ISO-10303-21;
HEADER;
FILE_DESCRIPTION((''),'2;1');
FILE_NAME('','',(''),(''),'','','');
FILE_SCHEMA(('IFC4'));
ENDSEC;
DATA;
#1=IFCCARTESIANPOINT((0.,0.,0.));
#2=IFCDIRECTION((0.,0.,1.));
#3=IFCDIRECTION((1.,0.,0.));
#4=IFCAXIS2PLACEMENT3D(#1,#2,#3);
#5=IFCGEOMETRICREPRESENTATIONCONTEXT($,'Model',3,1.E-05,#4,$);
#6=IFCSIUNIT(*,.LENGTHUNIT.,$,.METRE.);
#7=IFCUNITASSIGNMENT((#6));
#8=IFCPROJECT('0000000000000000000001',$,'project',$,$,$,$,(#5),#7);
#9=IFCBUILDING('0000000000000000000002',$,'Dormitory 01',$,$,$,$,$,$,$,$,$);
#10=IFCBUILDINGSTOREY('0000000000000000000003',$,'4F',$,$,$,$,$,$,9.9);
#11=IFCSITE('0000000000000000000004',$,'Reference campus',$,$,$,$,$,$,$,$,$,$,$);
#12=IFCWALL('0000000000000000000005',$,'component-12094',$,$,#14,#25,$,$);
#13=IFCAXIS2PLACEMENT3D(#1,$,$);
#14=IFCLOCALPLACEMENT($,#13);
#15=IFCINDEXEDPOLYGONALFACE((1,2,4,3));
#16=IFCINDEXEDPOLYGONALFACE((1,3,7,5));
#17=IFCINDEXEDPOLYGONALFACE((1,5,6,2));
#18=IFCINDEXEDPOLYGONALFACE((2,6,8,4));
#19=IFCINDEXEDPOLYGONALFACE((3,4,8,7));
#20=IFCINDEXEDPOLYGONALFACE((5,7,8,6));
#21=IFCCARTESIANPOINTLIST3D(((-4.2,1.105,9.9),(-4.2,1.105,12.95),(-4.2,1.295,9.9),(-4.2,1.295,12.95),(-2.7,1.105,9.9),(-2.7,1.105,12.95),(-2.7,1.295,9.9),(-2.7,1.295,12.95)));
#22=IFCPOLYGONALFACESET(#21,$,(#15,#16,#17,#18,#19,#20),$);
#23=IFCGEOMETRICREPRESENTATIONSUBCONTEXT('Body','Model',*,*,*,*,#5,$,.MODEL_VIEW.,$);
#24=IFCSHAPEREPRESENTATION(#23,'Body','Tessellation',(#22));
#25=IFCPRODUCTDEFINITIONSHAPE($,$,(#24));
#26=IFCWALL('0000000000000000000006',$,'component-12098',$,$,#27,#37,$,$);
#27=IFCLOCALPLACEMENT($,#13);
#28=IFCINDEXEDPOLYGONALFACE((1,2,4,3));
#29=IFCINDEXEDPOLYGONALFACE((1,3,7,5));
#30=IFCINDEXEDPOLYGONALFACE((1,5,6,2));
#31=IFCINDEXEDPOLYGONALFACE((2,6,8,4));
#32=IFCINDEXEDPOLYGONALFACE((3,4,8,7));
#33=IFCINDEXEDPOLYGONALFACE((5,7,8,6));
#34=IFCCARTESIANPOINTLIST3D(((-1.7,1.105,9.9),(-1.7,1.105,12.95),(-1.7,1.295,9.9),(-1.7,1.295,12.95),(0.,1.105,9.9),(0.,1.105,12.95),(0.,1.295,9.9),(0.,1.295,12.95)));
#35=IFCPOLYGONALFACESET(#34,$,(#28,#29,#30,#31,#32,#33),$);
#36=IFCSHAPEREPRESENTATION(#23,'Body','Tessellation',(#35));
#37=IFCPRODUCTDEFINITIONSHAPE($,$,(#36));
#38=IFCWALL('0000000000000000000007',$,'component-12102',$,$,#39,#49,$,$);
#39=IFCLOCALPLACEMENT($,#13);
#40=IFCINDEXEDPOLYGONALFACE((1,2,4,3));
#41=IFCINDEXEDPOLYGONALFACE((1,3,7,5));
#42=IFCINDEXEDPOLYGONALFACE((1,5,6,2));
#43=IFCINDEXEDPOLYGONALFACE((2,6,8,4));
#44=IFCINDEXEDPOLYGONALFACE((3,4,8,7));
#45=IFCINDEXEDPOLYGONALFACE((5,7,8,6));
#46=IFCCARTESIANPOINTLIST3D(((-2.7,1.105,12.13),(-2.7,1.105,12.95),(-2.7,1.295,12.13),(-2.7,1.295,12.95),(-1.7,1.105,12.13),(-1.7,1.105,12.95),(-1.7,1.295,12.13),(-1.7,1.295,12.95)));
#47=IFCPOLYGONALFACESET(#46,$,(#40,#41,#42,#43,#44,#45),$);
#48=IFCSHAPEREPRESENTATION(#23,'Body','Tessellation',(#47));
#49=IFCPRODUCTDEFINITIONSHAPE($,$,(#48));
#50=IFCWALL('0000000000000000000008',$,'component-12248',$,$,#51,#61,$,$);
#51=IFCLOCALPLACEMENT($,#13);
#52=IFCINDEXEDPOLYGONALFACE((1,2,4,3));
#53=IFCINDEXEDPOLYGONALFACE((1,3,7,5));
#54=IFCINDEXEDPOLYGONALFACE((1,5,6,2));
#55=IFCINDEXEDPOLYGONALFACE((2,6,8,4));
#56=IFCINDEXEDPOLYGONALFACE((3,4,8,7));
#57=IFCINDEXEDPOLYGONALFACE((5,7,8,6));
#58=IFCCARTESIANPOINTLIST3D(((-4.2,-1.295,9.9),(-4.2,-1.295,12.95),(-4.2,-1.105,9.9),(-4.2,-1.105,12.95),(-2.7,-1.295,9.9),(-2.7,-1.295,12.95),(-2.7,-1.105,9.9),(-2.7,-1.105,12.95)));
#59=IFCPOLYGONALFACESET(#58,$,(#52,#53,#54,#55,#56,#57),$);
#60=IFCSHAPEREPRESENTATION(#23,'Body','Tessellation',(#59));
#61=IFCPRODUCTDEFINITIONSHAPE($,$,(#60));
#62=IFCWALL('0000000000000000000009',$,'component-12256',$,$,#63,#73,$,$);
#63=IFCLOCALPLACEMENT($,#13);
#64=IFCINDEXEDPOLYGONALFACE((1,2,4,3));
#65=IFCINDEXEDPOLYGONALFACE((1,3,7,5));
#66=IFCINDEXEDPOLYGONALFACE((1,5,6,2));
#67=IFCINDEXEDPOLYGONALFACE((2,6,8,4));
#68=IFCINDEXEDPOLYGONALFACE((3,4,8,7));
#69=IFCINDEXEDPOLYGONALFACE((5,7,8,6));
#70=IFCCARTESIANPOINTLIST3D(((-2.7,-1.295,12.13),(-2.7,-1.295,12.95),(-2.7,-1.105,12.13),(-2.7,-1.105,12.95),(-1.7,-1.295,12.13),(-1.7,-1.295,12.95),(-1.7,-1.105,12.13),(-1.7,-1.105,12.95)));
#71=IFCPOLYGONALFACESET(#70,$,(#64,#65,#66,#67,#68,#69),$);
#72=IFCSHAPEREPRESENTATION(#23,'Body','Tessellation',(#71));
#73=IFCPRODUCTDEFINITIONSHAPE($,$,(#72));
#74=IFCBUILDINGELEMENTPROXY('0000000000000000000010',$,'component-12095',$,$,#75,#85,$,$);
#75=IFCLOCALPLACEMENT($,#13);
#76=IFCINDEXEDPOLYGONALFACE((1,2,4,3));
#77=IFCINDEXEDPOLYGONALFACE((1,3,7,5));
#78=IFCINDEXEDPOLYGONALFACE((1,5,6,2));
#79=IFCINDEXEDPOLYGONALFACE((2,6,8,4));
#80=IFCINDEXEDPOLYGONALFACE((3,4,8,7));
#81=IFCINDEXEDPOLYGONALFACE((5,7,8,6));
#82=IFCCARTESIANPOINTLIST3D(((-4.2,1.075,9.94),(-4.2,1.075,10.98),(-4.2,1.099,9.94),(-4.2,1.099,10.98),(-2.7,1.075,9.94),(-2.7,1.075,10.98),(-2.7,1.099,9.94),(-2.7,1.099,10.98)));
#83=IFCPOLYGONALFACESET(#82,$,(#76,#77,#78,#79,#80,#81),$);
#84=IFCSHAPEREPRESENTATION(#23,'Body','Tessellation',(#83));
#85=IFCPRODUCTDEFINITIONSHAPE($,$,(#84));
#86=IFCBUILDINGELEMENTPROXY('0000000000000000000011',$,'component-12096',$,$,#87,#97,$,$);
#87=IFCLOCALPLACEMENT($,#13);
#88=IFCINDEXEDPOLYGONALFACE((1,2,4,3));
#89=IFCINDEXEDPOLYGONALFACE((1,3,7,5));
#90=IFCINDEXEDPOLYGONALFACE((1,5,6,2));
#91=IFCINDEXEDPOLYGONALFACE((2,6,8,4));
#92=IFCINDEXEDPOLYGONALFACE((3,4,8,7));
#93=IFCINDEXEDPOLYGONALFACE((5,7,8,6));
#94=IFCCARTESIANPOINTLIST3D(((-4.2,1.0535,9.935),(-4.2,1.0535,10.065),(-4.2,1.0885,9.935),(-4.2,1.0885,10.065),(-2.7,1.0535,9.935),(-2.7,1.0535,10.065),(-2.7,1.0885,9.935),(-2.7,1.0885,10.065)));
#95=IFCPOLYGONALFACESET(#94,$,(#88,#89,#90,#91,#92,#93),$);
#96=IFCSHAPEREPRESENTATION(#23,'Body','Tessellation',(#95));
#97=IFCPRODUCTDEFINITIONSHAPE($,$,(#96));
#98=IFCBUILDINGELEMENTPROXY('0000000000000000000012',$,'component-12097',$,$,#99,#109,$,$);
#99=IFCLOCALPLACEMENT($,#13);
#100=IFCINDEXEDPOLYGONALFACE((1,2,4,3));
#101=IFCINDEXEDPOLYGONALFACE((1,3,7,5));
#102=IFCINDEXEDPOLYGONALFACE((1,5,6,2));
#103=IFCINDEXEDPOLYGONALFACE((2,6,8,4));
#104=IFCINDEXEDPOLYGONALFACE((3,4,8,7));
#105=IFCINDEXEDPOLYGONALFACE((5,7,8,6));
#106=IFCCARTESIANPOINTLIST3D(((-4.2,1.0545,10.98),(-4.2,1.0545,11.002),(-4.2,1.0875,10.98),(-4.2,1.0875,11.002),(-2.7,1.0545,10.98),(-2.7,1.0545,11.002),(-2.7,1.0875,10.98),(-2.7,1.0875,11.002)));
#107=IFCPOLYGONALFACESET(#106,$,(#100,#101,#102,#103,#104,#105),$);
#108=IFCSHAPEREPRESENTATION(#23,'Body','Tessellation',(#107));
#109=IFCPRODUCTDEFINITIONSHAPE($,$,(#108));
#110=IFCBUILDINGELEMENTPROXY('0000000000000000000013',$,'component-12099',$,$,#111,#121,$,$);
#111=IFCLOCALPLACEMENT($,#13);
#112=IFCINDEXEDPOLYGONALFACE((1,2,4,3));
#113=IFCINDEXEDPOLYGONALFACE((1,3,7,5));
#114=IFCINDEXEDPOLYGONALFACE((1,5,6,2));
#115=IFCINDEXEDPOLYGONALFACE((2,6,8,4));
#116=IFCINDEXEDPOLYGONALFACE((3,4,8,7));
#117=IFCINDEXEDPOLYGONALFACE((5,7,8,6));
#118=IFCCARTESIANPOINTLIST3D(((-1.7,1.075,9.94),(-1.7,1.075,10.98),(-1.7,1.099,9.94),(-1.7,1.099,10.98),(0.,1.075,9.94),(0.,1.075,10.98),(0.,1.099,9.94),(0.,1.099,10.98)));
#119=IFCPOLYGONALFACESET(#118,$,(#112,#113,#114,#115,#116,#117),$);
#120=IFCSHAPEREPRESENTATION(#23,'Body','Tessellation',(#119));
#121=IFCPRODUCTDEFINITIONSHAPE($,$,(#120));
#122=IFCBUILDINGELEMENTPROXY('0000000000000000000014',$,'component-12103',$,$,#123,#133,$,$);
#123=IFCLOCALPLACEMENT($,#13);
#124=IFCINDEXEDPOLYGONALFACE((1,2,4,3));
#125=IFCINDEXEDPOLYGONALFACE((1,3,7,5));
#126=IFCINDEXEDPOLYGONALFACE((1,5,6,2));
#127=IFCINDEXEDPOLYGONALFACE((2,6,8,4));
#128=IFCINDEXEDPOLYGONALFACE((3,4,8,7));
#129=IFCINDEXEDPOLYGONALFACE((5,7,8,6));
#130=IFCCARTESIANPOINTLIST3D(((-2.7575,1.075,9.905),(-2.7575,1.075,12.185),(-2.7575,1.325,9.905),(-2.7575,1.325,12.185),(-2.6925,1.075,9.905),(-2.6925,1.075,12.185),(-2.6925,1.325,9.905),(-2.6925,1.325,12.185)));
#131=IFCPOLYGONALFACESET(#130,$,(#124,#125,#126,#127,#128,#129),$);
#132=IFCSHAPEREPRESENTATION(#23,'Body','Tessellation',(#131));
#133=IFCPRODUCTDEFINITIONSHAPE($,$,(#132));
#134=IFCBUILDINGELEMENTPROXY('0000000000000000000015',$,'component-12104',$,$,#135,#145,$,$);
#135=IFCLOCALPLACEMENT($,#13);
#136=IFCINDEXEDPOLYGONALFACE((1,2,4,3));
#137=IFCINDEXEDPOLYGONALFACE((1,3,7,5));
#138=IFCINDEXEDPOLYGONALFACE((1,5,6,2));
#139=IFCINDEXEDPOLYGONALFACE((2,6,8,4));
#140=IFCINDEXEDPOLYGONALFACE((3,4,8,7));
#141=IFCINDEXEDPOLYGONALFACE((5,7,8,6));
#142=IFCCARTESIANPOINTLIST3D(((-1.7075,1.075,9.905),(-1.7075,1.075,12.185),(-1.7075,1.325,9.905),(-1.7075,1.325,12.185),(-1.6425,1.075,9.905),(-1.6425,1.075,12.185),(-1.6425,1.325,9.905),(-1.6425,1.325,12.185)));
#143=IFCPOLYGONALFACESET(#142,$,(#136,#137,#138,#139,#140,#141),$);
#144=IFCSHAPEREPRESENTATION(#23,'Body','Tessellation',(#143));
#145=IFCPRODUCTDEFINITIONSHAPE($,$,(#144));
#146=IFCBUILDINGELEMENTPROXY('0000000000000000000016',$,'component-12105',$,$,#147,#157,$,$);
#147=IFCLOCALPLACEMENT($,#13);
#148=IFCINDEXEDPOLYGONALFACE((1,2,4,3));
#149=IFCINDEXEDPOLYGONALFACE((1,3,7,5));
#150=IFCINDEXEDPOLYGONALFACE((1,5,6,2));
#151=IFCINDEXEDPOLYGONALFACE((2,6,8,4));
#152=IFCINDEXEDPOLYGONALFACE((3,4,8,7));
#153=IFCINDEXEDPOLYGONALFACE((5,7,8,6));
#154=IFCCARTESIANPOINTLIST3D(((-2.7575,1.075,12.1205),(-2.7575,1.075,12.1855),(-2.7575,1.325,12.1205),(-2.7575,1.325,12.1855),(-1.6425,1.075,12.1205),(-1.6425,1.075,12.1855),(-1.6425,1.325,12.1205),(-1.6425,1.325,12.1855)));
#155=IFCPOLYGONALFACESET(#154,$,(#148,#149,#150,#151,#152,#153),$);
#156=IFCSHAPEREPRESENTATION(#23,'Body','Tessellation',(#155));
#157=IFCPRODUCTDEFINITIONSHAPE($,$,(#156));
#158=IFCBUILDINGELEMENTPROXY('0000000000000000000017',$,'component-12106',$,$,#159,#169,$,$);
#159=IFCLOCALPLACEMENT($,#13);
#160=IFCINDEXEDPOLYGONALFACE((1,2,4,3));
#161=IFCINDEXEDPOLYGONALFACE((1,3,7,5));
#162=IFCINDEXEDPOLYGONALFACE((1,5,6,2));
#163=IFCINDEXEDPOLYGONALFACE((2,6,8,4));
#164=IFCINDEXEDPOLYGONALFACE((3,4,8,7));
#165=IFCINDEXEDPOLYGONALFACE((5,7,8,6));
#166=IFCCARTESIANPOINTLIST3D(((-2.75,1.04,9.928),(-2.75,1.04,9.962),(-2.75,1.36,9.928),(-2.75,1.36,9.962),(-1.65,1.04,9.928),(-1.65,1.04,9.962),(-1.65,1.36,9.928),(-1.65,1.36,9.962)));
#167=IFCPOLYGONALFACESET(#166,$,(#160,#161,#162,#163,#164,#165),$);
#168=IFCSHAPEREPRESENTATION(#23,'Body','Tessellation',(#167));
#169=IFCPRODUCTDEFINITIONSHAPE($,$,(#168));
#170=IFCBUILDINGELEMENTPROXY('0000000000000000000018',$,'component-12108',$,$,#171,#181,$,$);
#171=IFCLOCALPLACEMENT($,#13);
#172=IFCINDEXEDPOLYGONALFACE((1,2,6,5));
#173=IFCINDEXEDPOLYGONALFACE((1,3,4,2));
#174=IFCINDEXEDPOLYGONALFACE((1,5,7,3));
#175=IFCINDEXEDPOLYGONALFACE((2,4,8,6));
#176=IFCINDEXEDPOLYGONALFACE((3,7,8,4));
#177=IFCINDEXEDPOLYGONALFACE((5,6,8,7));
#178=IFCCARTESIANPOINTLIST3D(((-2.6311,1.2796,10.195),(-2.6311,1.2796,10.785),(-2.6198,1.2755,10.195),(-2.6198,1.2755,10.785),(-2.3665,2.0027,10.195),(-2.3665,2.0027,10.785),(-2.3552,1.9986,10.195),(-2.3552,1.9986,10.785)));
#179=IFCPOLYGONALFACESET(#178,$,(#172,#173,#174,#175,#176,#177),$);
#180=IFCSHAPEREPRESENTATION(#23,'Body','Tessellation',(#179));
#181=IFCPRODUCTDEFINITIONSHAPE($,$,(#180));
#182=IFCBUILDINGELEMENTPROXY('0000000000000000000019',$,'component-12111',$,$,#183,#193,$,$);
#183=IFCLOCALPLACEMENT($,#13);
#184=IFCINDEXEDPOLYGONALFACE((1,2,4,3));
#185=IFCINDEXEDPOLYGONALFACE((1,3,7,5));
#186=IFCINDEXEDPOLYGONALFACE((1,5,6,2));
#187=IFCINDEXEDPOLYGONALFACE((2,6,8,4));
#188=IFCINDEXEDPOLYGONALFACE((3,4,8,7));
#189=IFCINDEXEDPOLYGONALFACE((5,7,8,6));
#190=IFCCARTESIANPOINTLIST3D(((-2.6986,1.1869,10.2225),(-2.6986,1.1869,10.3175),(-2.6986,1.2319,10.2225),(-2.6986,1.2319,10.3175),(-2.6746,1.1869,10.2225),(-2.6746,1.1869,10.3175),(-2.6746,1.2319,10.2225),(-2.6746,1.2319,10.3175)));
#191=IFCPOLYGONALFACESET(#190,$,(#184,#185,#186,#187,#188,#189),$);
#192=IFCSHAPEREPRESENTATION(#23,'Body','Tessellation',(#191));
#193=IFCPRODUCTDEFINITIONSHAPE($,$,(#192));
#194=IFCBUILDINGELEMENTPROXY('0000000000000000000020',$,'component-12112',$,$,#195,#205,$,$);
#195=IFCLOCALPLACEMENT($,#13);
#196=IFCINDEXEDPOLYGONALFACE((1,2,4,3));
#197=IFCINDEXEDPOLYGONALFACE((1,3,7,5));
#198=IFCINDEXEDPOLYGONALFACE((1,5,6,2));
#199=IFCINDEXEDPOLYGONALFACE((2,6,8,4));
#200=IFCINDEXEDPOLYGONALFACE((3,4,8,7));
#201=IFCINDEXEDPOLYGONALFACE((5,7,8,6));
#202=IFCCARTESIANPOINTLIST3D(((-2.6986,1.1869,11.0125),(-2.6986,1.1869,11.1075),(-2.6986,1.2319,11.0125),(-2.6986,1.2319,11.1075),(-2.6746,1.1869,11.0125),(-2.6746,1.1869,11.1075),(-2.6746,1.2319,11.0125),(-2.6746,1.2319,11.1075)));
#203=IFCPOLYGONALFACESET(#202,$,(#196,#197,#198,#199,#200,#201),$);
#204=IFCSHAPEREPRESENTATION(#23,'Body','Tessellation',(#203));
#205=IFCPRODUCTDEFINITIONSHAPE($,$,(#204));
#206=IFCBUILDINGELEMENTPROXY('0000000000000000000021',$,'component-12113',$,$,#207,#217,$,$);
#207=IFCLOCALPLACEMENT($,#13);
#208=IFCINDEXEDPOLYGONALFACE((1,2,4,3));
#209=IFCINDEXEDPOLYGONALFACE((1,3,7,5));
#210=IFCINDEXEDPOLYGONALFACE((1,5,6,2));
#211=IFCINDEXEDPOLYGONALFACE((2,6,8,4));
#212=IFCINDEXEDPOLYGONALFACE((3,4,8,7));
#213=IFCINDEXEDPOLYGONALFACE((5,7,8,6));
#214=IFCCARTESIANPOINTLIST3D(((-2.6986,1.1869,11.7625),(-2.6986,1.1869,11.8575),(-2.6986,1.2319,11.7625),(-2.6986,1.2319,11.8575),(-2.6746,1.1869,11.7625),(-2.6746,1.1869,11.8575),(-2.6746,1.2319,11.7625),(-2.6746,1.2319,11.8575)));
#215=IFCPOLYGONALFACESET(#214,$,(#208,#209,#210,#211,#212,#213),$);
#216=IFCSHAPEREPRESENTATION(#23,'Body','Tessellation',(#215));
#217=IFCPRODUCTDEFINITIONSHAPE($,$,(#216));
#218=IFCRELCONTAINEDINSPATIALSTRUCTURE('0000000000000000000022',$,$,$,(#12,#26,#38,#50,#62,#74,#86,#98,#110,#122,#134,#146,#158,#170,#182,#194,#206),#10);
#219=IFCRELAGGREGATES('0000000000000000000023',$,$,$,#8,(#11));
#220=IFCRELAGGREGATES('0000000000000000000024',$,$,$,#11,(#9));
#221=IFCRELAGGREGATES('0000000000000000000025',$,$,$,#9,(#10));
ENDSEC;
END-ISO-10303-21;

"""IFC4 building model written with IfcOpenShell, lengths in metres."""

from ifc_helpers import new_model, si_unit, frame, origin, origin_with_axes, origin_2d, place, context, subcontext, project, spatial, rectangle, extrude, element, save


model = new_model("IFC4")

# Units and contexts
model_context = context("Model", 3, precision=1e-05, world=origin_with_axes())
body_context = subcontext(model_context, "Body", "Model", "MODEL_VIEW")
ifc_project = project(units=[si_unit("LENGTHUNIT", "METRE")], contexts=[model_context])

# Site, building, storey
site = spatial("IfcSite", under=ifc_project, Name="Reference campus")
building = spatial("IfcBuilding", under=site, Name="Dormitory 01")
storey = spatial("IfcBuildingStorey", under=building, Name="4F", Elevation=9.9)

# Walls
wall_1_placement = place(None, frame((-3.45, 1.2, 9.9), z_axis=(0.0, 0.0, 1.0), x_axis=(1.0, 0.0, 0.0)))
element("IfcWall", 1, at=wall_1_placement, inside=storey, Name="component-12094", context=body_context, shape_type="SweptSolid", body=[
    extrude(rectangle(XDim=1.5, YDim=0.19, at=origin_2d()), origin(), (0.0, 0.0, 1.0), 3.05),
])
wall_2_placement = place(None, frame((-0.85, 1.2, 9.9), z_axis=(0.0, 0.0, 1.0), x_axis=(1.0, 0.0, 0.0)))
element("IfcWall", 2, at=wall_2_placement, inside=storey, Name="component-12098", context=body_context, shape_type="SweptSolid", body=[
    extrude(rectangle(XDim=1.7, YDim=0.19, at=origin_2d()), origin(), (0.0, 0.0, 1.0), 3.05),
])
wall_3_placement = place(None, frame((-2.2, 1.2, 12.13), z_axis=(0.0, 0.0, 1.0), x_axis=(1.0, 0.0, 0.0)))
element("IfcWall", 3, at=wall_3_placement, inside=storey, Name="component-12102", context=body_context, shape_type="SweptSolid", body=[
    extrude(rectangle(XDim=1.0, YDim=0.19, at=origin_2d()), origin(), (0.0, 0.0, 1.0), 0.82),
])
wall_4_placement = place(None, frame((-3.45, -1.2, 9.9), z_axis=(0.0, 0.0, 1.0), x_axis=(1.0, 0.0, 0.0)))
element("IfcWall", 4, at=wall_4_placement, inside=storey, Name="component-12248", context=body_context, shape_type="SweptSolid", body=[
    extrude(rectangle(XDim=1.5, YDim=0.19, at=origin_2d()), origin(), (0.0, 0.0, 1.0), 3.05),
])
wall_5_placement = place(None, frame((-2.2, -1.2, 12.13), z_axis=(0.0, 0.0, 1.0), x_axis=(1.0, 0.0, 0.0)))
element("IfcWall", 5, at=wall_5_placement, inside=storey, Name="component-12256", context=body_context, shape_type="SweptSolid", body=[
    extrude(rectangle(XDim=1.0, YDim=0.19, at=origin_2d()), origin(), (0.0, 0.0, 1.0), 0.82),
])

# Building element proxies
proxy_1_placement = place(None, frame((-3.45, 1.087, 9.94), z_axis=(0.0, 0.0, 1.0), x_axis=(1.0, 0.0, 0.0)))
element("IfcBuildingElementProxy", 6, at=proxy_1_placement, inside=storey, Name="component-12095", context=body_context, shape_type="SweptSolid", body=[
    extrude(rectangle(XDim=1.5, YDim=0.024, at=origin_2d()), origin(), (0.0, 0.0, 1.0), 1.04),
])
proxy_2_placement = place(None, frame((-3.45, 1.071, 9.935), z_axis=(0.0, 0.0, 1.0), x_axis=(1.0, 0.0, 0.0)))
element("IfcBuildingElementProxy", 7, at=proxy_2_placement, inside=storey, Name="component-12096", context=body_context, shape_type="SweptSolid", body=[
    extrude(rectangle(XDim=1.5, YDim=0.035, at=origin_2d()), origin(), (0.0, 0.0, 1.0), 0.13),
])
proxy_3_placement = place(None, frame((-3.45, 1.071, 10.98), z_axis=(0.0, 0.0, 1.0), x_axis=(1.0, 0.0, 0.0)))
element("IfcBuildingElementProxy", 8, at=proxy_3_placement, inside=storey, Name="component-12097", context=body_context, shape_type="SweptSolid", body=[
    extrude(rectangle(XDim=1.5, YDim=0.033, at=origin_2d()), origin(), (0.0, 0.0, 1.0), 0.022),
])
proxy_4_placement = place(None, frame((-0.85, 1.087, 9.94), z_axis=(0.0, 0.0, 1.0), x_axis=(1.0, 0.0, 0.0)))
element("IfcBuildingElementProxy", 9, at=proxy_4_placement, inside=storey, Name="component-12099", context=body_context, shape_type="SweptSolid", body=[
    extrude(rectangle(XDim=1.7, YDim=0.024, at=origin_2d()), origin(), (0.0, 0.0, 1.0), 1.04),
])
for number, where, z_axis, x_axis, name in (
    (10, (-2.725, 1.2, 9.905), (0.0, 0.0, 1.0), (1.0, 0.0, 0.0), "component-12103"),
    (11, (-1.675, 1.2, 9.905), (0.0, 0.0, 1.0), (1.0, 0.0, 0.0), "component-12104"),
):
    element("IfcBuildingElementProxy", number, at=place(None, frame(where, z_axis=z_axis, x_axis=x_axis)), inside=storey, Name=name, context=body_context, shape_type="SweptSolid", body=[
        extrude(rectangle(XDim=0.065, YDim=0.25, at=origin_2d()), origin(), (0.0, 0.0, 1.0), 2.28),
    ])
proxy_5_placement = place(None, frame((-2.2, 1.2, 12.1205), z_axis=(0.0, 0.0, 1.0), x_axis=(1.0, 0.0, 0.0)))
element("IfcBuildingElementProxy", 12, at=proxy_5_placement, inside=storey, Name="component-12105", context=body_context, shape_type="SweptSolid", body=[
    extrude(rectangle(XDim=1.115, YDim=0.25, at=origin_2d()), origin(), (0.0, 0.0, 1.0), 0.065),
])
proxy_6_placement = place(None, frame((-2.2, 1.2, 9.928), z_axis=(0.0, 0.0, 1.0), x_axis=(1.0, 0.0, 0.0)))
element("IfcBuildingElementProxy", 13, at=proxy_6_placement, inside=storey, Name="component-12106", context=body_context, shape_type="SweptSolid", body=[
    extrude(rectangle(XDim=1.1, YDim=0.32, at=origin_2d()), origin(), (0.0, 0.0, 1.0), 0.034),
])
proxy_7_placement = place(None, frame((-2.4931, 1.6391, 10.195), z_axis=(0.0, 0.0, 1.0), x_axis=(0.343646, 0.939099, 0.0)))
element("IfcBuildingElementProxy", 14, at=proxy_7_placement, inside=storey, Name="component-12108", context=body_context, shape_type="SweptSolid", body=[
    extrude(rectangle(XDim=0.77, YDim=0.012, at=origin_2d()), origin(), (0.0, 0.0, 1.0), 0.59),
])
for number, where, z_axis, x_axis, name in (
    (15, (-2.6866, 1.2094, 10.2225), (0.0, 0.0, 1.0), (1.0, 0.0, 0.0), "component-12111"),
    (16, (-2.6866, 1.2094, 11.0125), (0.0, 0.0, 1.0), (1.0, 0.0, 0.0), "component-12112"),
    (17, (-2.6866, 1.2094, 11.7625), (0.0, 0.0, 1.0), (1.0, 0.0, 0.0), "component-12113"),
):
    element("IfcBuildingElementProxy", number, at=place(None, frame(where, z_axis=z_axis, x_axis=x_axis)), inside=storey, Name=name, context=body_context, shape_type="SweptSolid", body=[
        extrude(rectangle(XDim=0.024, YDim=0.045, at=origin_2d()), origin(), (0.0, 0.0, 1.0), 0.095),
    ])

save(model, "model.ifc")
